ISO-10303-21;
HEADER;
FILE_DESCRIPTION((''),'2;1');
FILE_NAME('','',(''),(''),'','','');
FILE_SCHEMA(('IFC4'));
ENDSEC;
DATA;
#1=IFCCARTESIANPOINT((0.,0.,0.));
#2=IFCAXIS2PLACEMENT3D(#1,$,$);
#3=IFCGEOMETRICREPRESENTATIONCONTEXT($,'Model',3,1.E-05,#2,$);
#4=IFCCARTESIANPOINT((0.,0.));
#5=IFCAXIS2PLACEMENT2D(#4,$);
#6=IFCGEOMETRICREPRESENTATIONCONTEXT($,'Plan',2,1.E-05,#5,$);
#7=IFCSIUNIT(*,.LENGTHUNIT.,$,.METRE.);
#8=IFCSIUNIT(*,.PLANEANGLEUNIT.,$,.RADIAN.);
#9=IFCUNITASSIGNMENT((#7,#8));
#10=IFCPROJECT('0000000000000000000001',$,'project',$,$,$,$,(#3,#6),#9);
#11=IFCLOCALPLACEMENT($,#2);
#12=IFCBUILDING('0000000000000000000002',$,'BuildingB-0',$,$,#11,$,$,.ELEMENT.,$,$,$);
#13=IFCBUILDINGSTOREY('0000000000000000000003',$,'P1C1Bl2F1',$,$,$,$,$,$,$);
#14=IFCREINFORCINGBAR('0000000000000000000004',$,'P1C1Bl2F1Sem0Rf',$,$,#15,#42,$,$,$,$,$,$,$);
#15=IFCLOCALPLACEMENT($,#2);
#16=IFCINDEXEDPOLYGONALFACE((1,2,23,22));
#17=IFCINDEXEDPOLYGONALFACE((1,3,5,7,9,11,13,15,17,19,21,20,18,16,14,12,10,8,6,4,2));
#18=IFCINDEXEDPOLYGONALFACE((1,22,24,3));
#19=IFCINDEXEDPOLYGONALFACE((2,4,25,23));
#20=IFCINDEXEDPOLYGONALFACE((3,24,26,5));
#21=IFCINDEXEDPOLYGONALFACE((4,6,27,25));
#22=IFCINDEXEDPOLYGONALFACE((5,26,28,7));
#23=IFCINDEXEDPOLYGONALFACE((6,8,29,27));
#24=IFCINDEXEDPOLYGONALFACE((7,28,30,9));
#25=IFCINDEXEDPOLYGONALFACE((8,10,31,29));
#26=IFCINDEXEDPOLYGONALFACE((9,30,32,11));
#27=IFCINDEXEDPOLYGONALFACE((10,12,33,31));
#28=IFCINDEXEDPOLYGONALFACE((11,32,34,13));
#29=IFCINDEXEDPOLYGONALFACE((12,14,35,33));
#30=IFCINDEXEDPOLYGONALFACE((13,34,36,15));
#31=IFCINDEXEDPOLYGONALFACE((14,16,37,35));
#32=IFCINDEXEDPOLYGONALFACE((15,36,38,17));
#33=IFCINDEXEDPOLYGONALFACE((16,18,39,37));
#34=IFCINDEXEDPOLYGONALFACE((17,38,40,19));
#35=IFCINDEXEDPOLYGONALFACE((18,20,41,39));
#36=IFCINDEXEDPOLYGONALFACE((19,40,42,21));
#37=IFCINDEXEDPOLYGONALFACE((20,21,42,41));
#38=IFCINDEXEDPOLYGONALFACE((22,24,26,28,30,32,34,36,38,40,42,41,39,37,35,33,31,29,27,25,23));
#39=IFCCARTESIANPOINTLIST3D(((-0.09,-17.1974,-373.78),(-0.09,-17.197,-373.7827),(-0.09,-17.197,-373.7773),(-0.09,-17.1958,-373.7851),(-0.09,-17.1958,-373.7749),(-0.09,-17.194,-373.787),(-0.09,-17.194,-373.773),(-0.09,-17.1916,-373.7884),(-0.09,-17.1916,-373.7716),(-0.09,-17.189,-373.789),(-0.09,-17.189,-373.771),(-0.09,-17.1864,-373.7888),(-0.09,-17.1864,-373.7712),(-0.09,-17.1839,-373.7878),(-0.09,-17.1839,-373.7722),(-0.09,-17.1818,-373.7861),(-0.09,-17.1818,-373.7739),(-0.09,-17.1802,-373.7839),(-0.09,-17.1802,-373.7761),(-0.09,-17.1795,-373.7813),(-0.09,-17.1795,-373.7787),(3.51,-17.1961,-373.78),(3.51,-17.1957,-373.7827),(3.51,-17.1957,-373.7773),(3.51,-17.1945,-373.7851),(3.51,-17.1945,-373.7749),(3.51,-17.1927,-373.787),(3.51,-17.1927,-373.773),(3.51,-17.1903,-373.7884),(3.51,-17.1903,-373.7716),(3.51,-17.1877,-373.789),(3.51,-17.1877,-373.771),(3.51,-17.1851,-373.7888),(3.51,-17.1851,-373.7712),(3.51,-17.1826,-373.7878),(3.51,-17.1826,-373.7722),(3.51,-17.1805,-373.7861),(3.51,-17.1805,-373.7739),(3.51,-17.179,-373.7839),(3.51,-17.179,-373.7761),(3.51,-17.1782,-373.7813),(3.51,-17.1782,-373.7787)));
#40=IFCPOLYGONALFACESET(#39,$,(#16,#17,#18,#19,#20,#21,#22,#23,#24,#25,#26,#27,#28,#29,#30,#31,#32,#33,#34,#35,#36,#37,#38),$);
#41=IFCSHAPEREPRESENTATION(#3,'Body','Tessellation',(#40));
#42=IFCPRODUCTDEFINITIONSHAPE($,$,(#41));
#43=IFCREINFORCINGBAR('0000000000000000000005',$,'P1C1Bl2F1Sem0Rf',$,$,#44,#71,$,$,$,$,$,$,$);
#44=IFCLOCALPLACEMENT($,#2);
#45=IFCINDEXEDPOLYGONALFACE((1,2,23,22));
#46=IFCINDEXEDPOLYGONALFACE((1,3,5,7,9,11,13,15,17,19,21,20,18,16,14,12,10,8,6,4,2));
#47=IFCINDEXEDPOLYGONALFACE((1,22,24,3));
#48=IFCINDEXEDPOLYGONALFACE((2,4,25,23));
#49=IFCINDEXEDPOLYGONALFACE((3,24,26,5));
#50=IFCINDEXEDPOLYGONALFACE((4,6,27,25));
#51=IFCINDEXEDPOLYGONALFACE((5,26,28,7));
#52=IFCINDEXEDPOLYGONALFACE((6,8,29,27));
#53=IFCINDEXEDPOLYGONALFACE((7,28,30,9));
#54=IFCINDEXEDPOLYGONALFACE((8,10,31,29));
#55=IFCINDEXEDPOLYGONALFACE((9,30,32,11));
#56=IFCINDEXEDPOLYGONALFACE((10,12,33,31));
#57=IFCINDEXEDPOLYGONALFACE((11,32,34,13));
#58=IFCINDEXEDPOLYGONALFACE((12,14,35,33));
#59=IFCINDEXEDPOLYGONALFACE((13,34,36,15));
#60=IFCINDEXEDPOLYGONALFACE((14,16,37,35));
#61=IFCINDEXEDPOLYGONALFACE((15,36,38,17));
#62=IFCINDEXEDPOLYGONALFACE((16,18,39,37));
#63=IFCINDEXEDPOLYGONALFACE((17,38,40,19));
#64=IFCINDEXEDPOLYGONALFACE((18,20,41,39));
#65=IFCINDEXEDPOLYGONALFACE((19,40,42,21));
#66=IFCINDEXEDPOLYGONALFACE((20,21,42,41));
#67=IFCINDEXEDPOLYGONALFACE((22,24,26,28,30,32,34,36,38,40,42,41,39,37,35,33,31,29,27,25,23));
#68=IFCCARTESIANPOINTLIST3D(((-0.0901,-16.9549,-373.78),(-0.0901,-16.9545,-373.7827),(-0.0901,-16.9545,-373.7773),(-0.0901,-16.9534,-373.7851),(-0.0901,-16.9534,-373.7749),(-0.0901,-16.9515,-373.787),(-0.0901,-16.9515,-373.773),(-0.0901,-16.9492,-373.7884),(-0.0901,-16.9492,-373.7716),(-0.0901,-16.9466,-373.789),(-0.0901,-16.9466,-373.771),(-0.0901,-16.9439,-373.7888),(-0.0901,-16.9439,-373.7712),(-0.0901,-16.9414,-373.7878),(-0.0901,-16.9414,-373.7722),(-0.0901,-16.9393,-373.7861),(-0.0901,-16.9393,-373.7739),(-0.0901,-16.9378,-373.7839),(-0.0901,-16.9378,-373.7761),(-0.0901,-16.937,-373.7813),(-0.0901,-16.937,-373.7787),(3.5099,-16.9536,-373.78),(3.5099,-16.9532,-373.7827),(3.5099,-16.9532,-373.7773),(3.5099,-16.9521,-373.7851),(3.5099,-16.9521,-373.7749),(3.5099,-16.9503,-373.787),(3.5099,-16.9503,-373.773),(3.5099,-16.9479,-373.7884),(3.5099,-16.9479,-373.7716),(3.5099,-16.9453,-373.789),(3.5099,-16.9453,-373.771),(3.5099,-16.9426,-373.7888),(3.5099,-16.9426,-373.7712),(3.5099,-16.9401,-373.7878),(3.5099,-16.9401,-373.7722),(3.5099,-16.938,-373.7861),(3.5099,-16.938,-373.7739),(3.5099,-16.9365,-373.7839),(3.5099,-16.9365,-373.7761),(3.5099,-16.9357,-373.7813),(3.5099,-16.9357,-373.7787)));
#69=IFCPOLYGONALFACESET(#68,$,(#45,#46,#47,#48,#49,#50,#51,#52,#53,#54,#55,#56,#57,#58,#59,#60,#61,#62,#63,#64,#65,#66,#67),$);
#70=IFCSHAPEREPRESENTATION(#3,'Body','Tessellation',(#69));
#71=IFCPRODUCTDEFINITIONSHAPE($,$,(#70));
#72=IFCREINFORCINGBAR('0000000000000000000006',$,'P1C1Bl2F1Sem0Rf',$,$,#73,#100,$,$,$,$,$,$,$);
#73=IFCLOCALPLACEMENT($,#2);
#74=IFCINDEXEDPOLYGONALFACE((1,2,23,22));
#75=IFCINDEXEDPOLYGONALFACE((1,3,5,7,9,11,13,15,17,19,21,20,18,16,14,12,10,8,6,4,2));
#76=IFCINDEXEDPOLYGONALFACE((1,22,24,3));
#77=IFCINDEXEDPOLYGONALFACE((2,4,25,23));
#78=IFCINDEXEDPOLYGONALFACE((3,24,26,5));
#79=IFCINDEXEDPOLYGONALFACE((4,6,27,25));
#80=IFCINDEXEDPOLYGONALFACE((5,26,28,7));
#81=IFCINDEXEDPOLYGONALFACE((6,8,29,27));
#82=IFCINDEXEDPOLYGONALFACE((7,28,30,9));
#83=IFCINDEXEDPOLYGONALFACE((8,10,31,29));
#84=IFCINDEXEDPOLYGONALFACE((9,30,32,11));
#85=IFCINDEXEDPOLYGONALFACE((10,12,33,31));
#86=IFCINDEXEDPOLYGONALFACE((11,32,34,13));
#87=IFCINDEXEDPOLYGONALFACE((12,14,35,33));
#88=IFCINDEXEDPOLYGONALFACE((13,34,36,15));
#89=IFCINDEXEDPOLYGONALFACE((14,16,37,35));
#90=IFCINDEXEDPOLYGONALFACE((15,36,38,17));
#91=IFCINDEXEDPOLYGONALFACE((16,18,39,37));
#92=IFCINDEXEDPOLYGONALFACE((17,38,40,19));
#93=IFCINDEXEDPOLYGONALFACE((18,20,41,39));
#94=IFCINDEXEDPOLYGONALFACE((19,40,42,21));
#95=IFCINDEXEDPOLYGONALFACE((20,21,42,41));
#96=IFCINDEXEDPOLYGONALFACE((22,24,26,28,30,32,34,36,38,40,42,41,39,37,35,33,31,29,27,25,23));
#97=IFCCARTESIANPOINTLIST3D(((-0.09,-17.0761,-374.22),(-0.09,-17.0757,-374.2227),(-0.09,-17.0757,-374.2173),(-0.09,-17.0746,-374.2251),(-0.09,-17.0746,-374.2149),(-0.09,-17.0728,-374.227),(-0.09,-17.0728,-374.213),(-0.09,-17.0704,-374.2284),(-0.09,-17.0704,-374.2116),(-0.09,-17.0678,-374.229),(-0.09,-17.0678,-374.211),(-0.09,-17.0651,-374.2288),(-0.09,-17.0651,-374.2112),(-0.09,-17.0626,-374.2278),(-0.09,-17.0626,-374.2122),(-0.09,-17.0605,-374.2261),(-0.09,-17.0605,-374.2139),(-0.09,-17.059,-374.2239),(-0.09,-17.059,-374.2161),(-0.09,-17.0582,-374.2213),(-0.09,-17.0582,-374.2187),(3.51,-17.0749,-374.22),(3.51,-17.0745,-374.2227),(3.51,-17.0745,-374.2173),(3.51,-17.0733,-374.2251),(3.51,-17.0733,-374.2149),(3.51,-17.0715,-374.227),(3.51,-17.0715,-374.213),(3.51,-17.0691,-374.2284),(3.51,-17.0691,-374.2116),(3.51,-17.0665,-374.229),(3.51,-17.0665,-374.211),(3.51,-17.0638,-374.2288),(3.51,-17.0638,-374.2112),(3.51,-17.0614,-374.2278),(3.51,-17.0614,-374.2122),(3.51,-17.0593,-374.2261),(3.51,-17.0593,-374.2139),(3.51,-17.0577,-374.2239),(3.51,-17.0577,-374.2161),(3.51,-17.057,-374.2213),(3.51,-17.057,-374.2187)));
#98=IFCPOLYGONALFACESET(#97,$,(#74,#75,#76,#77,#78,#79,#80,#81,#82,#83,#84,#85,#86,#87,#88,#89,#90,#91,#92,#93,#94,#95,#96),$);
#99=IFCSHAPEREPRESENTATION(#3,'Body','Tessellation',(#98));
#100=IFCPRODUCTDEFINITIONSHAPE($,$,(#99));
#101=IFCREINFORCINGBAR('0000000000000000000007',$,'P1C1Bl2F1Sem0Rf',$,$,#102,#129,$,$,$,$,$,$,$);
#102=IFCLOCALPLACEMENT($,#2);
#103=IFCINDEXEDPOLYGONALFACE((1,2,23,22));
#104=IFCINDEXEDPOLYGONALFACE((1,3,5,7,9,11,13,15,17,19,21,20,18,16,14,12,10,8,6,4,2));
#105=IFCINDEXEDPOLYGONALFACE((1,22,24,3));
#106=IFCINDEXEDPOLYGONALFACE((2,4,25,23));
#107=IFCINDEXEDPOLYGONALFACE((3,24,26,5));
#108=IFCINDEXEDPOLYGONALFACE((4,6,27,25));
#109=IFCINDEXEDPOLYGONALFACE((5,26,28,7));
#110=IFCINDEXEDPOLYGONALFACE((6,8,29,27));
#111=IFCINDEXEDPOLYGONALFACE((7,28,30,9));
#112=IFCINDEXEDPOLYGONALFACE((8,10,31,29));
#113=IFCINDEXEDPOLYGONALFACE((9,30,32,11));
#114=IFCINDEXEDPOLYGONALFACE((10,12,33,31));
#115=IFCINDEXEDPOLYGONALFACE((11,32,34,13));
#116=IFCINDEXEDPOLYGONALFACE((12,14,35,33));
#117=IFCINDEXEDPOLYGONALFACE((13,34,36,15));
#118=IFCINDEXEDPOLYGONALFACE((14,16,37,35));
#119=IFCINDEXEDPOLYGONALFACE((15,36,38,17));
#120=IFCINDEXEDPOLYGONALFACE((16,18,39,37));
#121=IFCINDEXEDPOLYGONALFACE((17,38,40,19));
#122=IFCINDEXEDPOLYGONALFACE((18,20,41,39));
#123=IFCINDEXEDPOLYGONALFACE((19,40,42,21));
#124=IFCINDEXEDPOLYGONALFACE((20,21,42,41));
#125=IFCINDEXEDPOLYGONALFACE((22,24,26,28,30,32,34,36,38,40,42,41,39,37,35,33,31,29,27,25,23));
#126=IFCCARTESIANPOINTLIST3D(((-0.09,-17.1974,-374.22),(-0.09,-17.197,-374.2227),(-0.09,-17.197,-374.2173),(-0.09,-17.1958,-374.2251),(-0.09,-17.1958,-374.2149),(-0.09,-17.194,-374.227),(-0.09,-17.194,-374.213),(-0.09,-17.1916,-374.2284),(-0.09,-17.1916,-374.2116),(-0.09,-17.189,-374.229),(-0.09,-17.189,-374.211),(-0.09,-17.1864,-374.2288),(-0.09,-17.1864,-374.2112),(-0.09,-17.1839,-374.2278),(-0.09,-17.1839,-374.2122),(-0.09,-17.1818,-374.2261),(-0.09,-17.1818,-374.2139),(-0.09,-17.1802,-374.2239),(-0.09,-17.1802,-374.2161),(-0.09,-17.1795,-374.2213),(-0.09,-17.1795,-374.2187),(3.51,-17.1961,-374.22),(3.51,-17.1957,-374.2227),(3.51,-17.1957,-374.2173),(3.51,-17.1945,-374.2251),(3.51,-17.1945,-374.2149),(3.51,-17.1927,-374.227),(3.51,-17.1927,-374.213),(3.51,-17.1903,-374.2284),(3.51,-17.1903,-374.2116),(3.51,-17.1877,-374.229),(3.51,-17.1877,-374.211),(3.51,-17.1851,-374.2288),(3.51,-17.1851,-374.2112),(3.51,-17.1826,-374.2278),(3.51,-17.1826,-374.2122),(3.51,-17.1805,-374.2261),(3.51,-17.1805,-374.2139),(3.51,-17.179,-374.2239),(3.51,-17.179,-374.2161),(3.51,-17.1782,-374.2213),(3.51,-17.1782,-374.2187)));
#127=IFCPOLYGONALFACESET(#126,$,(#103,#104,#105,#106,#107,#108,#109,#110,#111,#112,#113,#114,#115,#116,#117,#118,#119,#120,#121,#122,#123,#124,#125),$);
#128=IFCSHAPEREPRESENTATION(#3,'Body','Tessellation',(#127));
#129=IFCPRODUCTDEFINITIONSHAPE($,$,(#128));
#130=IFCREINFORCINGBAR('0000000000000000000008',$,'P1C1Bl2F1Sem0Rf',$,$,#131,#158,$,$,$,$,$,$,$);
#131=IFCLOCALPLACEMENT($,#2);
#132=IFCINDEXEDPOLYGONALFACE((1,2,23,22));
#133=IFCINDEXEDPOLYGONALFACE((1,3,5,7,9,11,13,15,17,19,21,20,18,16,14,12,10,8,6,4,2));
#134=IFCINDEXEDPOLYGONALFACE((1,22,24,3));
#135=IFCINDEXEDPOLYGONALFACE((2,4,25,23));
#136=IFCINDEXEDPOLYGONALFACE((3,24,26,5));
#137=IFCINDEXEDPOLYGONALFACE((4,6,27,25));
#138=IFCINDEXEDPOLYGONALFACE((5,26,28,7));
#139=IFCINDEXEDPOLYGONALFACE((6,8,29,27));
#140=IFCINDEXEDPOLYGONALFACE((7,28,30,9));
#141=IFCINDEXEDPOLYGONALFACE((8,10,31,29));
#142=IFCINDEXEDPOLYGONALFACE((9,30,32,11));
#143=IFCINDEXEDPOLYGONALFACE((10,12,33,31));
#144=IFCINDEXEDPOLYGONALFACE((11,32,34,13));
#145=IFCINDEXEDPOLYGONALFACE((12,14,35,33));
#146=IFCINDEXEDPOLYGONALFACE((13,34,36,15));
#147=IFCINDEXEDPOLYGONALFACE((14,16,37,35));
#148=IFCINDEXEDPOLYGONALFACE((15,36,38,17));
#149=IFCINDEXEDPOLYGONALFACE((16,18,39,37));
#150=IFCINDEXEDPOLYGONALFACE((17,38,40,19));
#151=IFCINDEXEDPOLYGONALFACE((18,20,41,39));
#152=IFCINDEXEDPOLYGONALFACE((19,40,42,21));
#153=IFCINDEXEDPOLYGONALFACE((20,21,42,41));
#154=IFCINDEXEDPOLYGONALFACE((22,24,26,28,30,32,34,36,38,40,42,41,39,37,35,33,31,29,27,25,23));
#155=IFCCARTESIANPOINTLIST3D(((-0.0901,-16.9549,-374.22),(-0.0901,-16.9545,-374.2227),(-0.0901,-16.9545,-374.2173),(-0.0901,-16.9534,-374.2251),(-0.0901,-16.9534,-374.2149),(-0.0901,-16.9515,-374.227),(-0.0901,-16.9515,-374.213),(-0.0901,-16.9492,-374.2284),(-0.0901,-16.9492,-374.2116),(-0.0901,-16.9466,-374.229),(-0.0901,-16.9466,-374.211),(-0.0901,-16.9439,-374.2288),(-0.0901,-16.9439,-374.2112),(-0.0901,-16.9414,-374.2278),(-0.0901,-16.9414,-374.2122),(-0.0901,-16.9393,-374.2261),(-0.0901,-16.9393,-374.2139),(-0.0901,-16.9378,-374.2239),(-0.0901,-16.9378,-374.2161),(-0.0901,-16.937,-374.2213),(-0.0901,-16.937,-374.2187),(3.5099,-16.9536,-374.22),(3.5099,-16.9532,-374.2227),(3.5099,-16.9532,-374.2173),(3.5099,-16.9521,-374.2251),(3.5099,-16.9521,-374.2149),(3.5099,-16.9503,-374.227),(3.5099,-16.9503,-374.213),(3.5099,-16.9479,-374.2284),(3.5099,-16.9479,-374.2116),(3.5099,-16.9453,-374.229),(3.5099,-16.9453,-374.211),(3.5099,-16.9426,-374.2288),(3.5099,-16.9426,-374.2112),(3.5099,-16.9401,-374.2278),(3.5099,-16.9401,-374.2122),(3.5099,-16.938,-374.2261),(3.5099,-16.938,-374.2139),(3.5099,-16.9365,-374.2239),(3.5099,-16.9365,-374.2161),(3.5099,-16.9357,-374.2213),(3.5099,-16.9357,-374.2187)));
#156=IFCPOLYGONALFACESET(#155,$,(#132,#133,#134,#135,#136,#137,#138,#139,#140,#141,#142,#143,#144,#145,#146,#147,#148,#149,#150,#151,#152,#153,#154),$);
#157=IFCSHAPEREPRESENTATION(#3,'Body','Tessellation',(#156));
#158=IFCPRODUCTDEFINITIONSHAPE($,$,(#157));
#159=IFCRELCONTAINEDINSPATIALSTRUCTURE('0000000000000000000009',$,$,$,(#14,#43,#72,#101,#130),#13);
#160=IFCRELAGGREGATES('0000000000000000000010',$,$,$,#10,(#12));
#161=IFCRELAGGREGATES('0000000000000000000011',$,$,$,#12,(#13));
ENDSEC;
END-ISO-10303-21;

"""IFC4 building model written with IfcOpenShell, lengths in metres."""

from ifc_helpers import new_model, entity, si_unit, origin, origin_2d, place, context, project, spatial, element, save


model = new_model("IFC4")

# Units and contexts
model_context = context("Model", 3, precision=1e-05, world=origin())
plan_context = context("Plan", 2, precision=1e-05, world=origin_2d())
ifc_project = project(units=[si_unit("LENGTHUNIT", "METRE"), si_unit("PLANEANGLEUNIT", "RADIAN")], contexts=[model_context, plan_context])

# Building, storey
building_placement = place(None, origin())
building = spatial("IfcBuilding", under=ifc_project, at=building_placement, Name="BuildingB-0", CompositionType="ELEMENT")
storey = spatial("IfcBuildingStorey", under=building, Name="P1C1Bl2F1")

# Reinforcing bars
element("IfcReinforcingBar", 1, inside=storey, Name="P1C1Bl2F1Sem0Rf", context=model_context, shape_type="SweptSolid", body=[
    entity("IfcSurfaceCurveSweptAreaSolid", entity("IfcCircleProfileDef", "AREA", None, None, 0.009), None, entity("IfcPolyline", [entity("IfcCartesianPoint", [0.09, 17.1884, 373.78]), entity("IfcCartesianPoint", [-3.51, 17.1871, 373.78])]), None, None, entity("IfcPlane", entity("IfcAxis2Placement3D", entity("IfcCartesianPoint", [0.09, 17.1884, 373.78]), entity("IfcDirection", [0.0, 0.0, 1.0]), entity("IfcDirection", [1.0, 0.0, 0.0])))),
])
element("IfcReinforcingBar", 2, inside=storey, Name="P1C1Bl2F1Sem0Rf", context=model_context, shape_type="SweptSolid", body=[
    entity("IfcSurfaceCurveSweptAreaSolid", entity("IfcCircleProfileDef", "AREA", None, None, 0.009), None, entity("IfcPolyline", [entity("IfcCartesianPoint", [0.0901, 16.9459, 373.78]), entity("IfcCartesianPoint", [-3.5099, 16.9446, 373.78])]), None, None, entity("IfcPlane", entity("IfcAxis2Placement3D", entity("IfcCartesianPoint", [0.0901, 16.9459, 373.78]), entity("IfcDirection", [0.0, 0.0, 1.0]), entity("IfcDirection", [1.0, 0.0, 0.0])))),
])
element("IfcReinforcingBar", 3, inside=storey, Name="P1C1Bl2F1Sem0Rf", context=model_context, shape_type="SweptSolid", body=[
    entity("IfcSurfaceCurveSweptAreaSolid", entity("IfcCircleProfileDef", "AREA", None, None, 0.009), None, entity("IfcPolyline", [entity("IfcCartesianPoint", [0.09, 17.0671, 374.22]), entity("IfcCartesianPoint", [-3.51, 17.0659, 374.22])]), None, None, entity("IfcPlane", entity("IfcAxis2Placement3D", entity("IfcCartesianPoint", [0.09, 17.0671, 374.22]), entity("IfcDirection", [0.0, 0.0, 1.0]), entity("IfcDirection", [1.0, 0.0, 0.0])))),
])
element("IfcReinforcingBar", 4, inside=storey, Name="P1C1Bl2F1Sem0Rf", context=model_context, shape_type="SweptSolid", body=[
    entity("IfcSurfaceCurveSweptAreaSolid", entity("IfcCircleProfileDef", "AREA", None, None, 0.009), None, entity("IfcPolyline", [entity("IfcCartesianPoint", [0.09, 17.1884, 374.22]), entity("IfcCartesianPoint", [-3.51, 17.1871, 374.22])]), None, None, entity("IfcPlane", entity("IfcAxis2Placement3D", entity("IfcCartesianPoint", [0.09, 17.1884, 374.22]), entity("IfcDirection", [0.0, 0.0, 1.0]), entity("IfcDirection", [1.0, 0.0, 0.0])))),
])
element("IfcReinforcingBar", 5, inside=storey, Name="P1C1Bl2F1Sem0Rf", context=model_context, shape_type="SweptSolid", body=[
    entity("IfcSurfaceCurveSweptAreaSolid", entity("IfcCircleProfileDef", "AREA", None, None, 0.009), None, entity("IfcPolyline", [entity("IfcCartesianPoint", [0.0901, 16.9459, 374.22]), entity("IfcCartesianPoint", [-3.5099, 16.9446, 374.22])]), None, None, entity("IfcPlane", entity("IfcAxis2Placement3D", entity("IfcCartesianPoint", [0.0901, 16.9459, 374.22]), entity("IfcDirection", [0.0, 0.0, 1.0]), entity("IfcDirection", [1.0, 0.0, 0.0])))),
])

save(model, "model.ifc")
